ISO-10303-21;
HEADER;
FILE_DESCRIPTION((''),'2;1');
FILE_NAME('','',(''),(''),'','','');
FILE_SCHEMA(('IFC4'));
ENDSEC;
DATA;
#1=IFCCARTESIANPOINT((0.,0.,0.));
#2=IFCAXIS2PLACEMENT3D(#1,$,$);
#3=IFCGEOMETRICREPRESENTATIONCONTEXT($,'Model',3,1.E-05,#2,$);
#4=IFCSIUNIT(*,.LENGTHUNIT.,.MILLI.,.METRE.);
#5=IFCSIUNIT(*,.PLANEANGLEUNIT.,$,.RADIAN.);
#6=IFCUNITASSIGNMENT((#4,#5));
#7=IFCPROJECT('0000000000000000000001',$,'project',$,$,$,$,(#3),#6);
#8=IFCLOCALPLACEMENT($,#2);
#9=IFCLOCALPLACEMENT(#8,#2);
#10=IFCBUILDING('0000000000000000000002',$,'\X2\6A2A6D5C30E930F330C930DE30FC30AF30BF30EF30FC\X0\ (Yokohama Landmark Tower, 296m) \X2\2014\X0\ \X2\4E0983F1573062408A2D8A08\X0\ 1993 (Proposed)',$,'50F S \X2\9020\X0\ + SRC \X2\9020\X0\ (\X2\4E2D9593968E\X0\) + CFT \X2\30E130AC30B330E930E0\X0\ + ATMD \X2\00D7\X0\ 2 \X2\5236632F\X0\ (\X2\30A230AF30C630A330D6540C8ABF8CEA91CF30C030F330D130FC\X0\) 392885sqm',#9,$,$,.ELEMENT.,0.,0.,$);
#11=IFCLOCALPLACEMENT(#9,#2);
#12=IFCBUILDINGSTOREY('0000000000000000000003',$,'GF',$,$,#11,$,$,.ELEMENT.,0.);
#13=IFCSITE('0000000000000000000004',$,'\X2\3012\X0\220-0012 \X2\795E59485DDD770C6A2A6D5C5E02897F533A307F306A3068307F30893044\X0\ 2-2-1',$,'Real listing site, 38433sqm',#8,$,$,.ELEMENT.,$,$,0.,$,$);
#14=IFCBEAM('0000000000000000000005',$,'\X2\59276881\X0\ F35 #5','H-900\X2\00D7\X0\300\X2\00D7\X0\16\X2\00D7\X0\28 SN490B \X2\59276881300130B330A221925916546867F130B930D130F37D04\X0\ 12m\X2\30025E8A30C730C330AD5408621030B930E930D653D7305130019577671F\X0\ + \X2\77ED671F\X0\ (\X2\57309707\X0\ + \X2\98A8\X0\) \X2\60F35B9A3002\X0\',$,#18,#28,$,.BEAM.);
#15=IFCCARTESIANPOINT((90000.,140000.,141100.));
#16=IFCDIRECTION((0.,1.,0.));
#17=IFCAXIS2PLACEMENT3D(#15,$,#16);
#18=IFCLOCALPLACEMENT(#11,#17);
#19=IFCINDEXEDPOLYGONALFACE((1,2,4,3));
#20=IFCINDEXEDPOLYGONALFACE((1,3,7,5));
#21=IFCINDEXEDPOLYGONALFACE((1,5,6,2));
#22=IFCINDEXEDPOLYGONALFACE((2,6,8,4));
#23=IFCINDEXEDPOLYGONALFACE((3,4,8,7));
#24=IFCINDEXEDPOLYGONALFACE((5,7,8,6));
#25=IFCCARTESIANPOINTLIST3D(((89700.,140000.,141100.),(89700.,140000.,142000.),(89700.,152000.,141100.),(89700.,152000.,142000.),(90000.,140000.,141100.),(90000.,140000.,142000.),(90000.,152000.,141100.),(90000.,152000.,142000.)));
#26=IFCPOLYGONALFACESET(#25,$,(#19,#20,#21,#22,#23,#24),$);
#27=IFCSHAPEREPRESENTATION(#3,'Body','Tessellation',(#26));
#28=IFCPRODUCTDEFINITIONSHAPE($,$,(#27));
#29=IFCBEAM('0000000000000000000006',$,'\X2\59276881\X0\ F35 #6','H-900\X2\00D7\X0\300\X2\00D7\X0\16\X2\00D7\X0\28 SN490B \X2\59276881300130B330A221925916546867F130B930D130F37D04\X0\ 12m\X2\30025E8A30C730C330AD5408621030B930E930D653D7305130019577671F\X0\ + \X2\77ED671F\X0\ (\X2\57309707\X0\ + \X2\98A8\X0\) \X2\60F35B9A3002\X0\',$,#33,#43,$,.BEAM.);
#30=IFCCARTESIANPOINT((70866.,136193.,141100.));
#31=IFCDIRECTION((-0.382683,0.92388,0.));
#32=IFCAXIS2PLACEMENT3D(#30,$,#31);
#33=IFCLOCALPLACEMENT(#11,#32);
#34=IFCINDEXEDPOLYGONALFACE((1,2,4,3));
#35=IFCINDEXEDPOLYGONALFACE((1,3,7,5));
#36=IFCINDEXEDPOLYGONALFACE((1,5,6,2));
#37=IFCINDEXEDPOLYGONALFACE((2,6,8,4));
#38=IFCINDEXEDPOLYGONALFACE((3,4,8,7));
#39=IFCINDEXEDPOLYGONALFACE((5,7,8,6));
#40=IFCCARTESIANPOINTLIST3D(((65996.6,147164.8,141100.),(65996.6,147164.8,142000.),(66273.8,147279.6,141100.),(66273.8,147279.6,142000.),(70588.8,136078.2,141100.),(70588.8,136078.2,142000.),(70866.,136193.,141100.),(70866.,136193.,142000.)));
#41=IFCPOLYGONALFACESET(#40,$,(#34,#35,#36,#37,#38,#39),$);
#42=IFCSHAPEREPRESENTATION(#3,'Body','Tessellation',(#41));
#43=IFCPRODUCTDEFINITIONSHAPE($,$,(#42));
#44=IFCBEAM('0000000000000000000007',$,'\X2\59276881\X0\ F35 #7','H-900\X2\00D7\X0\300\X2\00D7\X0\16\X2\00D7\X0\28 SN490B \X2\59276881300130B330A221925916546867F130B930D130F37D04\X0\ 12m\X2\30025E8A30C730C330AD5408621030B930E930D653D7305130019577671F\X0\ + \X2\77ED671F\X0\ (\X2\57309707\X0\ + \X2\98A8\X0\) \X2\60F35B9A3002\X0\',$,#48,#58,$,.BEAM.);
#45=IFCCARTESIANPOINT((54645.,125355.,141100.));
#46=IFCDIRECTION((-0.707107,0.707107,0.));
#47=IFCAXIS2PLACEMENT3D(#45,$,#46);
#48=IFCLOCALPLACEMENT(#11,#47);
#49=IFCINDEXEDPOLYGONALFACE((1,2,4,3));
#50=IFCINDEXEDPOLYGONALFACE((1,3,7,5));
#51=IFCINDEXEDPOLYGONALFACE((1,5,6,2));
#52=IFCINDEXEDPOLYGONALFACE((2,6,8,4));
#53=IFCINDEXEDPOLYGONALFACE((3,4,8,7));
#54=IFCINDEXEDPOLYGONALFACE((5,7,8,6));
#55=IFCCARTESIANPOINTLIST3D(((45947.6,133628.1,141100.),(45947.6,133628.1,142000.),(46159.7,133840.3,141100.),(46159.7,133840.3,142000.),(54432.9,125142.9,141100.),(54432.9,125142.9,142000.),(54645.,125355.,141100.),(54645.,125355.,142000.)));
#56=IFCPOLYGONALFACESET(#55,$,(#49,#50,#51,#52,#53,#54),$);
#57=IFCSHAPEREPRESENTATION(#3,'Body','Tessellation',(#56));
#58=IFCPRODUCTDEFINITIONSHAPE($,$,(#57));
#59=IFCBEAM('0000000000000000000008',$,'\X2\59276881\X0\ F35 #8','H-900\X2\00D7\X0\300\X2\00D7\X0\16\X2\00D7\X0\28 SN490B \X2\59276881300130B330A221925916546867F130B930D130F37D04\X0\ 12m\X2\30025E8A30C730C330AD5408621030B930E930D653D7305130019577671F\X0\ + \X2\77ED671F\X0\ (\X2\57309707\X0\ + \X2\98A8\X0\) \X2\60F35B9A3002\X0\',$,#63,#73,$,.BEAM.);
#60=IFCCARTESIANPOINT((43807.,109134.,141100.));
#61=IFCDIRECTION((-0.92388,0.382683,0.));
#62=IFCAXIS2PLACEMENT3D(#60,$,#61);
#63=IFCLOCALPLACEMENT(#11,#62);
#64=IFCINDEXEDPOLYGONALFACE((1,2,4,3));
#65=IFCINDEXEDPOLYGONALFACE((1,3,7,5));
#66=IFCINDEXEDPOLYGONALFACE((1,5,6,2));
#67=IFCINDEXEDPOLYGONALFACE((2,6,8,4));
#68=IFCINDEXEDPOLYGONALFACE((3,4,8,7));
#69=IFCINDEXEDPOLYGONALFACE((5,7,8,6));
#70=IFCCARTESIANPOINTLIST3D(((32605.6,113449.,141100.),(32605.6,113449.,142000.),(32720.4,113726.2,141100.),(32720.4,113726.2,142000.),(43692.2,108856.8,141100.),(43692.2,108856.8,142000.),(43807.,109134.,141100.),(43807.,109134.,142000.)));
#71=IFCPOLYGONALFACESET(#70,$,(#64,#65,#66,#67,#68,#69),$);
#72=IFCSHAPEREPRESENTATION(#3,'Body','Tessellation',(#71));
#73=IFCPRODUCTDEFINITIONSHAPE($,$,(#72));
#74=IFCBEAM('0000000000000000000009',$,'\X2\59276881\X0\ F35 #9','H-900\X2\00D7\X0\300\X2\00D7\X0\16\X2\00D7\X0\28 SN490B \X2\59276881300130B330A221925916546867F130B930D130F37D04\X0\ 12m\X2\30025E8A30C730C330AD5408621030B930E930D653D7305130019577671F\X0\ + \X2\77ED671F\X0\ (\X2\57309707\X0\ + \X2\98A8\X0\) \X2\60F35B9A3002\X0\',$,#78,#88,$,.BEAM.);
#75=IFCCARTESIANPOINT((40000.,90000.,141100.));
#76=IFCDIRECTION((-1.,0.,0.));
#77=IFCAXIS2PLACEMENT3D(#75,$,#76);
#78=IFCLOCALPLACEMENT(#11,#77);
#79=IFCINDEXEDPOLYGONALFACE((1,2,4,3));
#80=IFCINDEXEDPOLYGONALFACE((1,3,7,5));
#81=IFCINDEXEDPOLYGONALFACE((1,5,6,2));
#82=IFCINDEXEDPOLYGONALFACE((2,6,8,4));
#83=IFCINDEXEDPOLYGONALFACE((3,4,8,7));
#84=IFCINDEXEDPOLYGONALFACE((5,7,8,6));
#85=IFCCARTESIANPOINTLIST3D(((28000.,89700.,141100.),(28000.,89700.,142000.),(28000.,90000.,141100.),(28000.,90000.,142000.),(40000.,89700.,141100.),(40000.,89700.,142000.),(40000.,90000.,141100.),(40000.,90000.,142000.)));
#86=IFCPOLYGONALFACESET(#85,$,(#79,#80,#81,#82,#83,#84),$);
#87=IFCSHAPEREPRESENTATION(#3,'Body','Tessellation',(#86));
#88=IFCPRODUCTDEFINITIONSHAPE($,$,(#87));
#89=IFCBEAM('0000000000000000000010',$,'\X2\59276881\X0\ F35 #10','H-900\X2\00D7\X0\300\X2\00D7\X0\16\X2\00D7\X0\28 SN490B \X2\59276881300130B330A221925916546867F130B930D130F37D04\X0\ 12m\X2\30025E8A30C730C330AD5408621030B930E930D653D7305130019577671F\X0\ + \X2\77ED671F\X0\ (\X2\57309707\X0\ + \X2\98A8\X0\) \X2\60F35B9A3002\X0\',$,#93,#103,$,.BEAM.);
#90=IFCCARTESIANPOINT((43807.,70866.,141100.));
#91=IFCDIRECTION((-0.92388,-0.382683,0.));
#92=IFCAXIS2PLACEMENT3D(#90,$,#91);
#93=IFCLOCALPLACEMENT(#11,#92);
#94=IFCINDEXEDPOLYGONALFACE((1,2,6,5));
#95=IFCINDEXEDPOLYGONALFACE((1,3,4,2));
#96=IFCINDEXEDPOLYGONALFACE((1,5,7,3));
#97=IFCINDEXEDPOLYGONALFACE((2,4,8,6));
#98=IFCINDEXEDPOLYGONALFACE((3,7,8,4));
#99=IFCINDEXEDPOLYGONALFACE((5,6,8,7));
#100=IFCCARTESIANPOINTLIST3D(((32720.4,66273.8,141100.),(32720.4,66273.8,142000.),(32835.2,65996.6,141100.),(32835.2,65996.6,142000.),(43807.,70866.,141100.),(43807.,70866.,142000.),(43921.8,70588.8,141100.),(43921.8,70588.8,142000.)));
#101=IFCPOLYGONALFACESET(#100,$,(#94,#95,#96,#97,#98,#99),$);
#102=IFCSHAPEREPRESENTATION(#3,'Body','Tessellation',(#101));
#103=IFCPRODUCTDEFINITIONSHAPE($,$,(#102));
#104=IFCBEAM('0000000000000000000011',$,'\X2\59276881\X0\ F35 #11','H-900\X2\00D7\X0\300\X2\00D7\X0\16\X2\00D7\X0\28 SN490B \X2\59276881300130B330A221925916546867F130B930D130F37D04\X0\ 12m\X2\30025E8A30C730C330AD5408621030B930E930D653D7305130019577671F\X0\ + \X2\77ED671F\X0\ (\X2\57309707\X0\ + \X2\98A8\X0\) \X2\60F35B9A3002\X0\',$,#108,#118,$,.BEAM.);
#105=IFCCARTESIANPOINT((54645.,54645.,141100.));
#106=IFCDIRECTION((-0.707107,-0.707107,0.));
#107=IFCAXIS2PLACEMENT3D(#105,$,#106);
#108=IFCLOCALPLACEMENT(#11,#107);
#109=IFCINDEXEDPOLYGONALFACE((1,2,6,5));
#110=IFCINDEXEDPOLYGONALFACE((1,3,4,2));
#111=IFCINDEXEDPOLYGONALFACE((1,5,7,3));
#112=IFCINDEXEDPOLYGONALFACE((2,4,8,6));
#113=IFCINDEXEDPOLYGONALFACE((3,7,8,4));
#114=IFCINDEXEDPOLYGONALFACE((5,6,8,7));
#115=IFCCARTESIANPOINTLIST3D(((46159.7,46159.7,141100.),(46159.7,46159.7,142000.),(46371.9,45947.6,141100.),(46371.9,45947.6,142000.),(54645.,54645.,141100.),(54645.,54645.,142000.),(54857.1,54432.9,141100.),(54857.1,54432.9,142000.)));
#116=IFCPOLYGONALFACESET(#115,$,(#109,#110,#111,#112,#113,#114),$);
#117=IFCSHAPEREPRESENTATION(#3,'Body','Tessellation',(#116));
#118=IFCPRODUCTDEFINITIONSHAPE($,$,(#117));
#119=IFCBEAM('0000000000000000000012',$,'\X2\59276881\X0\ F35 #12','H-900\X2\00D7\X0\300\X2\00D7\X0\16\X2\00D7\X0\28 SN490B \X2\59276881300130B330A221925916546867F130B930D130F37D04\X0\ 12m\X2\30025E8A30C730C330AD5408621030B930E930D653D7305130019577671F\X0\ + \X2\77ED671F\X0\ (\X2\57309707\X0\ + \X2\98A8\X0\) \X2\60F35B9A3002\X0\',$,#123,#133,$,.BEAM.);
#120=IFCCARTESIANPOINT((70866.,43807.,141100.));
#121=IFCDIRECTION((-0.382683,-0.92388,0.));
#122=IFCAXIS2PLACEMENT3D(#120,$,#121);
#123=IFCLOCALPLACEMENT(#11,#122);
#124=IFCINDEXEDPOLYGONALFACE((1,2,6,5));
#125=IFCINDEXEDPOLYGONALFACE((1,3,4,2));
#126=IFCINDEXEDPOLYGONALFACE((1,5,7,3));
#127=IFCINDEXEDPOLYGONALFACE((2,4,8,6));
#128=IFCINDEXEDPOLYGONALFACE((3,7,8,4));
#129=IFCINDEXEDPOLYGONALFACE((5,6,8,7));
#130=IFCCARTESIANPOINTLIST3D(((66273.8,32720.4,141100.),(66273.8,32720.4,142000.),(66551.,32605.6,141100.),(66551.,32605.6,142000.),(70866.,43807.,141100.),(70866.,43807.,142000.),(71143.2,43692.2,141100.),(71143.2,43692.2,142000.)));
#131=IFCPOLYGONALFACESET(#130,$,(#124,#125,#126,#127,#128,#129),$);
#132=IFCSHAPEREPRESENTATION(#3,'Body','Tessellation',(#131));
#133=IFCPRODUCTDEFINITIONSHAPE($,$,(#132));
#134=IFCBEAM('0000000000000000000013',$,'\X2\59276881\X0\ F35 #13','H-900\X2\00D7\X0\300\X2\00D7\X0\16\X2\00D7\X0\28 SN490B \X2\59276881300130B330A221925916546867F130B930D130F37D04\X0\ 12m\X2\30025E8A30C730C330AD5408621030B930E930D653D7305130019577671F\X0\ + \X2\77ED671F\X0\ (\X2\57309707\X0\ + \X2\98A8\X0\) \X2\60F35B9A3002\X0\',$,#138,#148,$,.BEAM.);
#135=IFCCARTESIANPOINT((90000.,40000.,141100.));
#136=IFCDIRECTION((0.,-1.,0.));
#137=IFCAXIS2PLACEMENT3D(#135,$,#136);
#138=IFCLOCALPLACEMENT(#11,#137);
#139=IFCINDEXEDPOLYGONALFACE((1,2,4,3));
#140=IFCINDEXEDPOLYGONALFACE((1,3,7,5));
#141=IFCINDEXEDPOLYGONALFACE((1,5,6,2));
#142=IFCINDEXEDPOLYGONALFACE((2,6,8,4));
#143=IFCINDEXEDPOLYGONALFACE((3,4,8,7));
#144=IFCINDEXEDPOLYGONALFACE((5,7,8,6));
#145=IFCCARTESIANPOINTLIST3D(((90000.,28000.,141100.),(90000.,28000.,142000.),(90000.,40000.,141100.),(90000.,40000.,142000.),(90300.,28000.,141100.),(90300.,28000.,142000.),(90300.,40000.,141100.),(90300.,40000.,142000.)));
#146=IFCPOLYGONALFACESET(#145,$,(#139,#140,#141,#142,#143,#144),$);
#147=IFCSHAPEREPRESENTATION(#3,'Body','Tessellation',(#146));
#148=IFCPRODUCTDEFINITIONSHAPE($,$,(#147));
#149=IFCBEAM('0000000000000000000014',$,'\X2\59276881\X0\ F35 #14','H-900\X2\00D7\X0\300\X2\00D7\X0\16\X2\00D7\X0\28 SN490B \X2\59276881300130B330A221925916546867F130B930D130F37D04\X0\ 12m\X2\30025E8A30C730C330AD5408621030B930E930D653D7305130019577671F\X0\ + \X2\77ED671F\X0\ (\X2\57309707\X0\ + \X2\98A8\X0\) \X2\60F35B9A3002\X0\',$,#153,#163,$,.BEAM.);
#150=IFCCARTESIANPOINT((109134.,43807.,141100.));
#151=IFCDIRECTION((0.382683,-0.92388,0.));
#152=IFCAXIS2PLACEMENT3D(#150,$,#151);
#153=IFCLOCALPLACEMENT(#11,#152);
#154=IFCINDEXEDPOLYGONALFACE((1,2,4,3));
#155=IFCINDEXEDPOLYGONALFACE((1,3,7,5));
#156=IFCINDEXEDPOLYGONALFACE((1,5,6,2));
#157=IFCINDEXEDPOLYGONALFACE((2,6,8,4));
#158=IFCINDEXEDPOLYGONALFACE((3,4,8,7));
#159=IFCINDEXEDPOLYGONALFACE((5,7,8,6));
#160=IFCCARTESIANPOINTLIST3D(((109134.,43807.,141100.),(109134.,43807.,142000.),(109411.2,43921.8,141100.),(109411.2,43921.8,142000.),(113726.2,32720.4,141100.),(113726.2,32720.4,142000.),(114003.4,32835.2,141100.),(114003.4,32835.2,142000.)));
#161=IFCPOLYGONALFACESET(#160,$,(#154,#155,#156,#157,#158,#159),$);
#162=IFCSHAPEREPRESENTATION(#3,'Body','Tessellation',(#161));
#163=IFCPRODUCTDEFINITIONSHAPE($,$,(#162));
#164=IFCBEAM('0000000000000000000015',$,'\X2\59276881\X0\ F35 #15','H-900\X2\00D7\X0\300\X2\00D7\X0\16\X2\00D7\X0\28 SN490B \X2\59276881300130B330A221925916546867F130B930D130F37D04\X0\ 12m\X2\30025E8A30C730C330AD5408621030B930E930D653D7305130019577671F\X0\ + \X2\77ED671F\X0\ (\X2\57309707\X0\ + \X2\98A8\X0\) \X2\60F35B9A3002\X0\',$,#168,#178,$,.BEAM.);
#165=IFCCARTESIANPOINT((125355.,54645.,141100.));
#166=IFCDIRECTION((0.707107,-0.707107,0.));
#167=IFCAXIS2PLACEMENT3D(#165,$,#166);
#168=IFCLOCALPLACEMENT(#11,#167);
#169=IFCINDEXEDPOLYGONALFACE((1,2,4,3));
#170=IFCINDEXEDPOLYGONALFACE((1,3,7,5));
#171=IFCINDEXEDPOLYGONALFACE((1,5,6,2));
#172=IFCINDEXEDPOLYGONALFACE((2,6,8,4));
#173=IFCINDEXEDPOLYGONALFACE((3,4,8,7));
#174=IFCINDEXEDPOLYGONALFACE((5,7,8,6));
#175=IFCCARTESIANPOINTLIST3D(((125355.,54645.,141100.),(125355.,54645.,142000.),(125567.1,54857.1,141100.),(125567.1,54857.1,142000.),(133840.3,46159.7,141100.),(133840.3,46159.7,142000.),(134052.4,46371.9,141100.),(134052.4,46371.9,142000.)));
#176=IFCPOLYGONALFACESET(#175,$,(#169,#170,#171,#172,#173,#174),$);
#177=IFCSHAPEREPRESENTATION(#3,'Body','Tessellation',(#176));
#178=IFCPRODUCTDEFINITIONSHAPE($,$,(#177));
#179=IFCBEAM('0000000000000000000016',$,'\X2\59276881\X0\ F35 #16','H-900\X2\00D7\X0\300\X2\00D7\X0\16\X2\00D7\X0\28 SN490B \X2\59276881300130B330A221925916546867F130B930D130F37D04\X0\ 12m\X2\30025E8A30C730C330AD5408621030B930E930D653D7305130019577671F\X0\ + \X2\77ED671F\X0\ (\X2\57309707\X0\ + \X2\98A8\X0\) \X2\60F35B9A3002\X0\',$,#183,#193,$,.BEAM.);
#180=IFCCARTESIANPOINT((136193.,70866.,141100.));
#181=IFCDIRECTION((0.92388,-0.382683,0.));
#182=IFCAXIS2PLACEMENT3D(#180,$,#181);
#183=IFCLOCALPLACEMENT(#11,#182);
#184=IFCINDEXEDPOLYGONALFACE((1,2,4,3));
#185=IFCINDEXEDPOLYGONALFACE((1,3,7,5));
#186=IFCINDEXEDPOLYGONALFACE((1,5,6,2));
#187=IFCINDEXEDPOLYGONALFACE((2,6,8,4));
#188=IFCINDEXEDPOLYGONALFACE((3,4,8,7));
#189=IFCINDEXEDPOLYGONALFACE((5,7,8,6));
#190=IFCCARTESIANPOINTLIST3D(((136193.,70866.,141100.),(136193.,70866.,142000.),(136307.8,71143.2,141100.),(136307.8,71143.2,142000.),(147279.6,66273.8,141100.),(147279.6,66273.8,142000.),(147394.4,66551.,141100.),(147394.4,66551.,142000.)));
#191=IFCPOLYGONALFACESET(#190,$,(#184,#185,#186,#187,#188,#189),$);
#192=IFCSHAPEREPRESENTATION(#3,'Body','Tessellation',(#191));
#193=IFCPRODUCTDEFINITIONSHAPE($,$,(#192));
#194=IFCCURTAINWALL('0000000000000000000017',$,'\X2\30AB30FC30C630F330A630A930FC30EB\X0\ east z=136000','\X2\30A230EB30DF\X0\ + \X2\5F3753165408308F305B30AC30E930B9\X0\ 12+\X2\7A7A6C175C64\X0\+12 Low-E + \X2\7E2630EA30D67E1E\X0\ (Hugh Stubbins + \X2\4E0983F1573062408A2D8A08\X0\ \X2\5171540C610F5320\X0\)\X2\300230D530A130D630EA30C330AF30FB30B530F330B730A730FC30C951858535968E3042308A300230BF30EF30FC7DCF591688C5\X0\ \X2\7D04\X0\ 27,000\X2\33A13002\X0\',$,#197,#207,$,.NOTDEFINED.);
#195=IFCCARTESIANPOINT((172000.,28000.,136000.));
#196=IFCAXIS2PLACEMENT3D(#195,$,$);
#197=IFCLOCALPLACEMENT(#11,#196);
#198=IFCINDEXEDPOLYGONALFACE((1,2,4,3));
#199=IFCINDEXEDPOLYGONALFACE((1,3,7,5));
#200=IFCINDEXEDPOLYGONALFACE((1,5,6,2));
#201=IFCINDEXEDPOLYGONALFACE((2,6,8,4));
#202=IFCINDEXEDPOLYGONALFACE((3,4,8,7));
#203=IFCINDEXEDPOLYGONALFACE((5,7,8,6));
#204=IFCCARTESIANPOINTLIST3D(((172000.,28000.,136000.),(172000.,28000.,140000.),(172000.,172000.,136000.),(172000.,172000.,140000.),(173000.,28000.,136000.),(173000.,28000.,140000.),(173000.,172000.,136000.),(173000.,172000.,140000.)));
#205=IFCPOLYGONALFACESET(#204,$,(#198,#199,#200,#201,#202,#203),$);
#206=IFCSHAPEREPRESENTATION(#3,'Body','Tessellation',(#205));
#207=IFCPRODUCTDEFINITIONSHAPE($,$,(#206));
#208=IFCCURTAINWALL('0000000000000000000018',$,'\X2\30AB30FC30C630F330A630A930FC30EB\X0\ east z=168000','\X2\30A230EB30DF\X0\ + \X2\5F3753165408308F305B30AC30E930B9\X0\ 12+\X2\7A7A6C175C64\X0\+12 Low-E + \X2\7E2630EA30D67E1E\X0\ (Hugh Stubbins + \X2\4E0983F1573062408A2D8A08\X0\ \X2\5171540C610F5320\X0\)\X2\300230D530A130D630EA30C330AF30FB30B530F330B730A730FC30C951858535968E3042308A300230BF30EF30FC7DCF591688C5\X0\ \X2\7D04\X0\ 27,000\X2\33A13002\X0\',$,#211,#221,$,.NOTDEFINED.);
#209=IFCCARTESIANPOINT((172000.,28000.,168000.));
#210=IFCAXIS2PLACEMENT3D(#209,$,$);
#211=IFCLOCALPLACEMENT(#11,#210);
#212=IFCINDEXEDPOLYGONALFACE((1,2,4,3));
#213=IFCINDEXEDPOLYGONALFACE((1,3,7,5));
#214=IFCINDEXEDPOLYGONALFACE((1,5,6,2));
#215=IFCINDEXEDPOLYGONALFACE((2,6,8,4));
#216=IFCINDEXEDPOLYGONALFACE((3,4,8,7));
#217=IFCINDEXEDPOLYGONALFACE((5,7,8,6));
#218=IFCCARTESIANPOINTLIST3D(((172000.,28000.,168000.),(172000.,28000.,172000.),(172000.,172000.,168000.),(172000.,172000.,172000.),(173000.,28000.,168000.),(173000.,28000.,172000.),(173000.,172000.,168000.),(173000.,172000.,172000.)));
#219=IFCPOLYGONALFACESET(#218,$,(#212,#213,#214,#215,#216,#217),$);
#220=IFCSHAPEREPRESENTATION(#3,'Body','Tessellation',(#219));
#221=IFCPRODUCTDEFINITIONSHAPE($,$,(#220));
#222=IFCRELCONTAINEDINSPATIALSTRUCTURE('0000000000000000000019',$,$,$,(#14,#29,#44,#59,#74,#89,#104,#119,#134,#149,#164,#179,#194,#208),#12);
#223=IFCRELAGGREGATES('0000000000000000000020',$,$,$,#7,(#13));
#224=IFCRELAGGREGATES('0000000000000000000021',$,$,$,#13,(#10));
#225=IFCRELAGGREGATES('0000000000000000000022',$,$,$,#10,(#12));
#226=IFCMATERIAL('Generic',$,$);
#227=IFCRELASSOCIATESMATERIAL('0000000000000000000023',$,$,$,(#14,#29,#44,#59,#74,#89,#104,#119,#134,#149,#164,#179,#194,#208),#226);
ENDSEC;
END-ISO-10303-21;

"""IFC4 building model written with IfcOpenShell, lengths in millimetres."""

from ifc_helpers import new_model, si_unit, frame, frame_2d, origin, place, context, project, spatial, rectangle, extrude, material, element, save


model = new_model("IFC4")

# Units and contexts
model_context = context("Model", 3, precision=1e-05, world=origin())
ifc_project = project(units=[si_unit("LENGTHUNIT", "METRE", prefix="MILLI"), si_unit("PLANEANGLEUNIT", "RADIAN")], contexts=[model_context])

# Site, building, storey
site_placement = place(None, origin())
site = spatial("IfcSite", under=ifc_project, at=site_placement, Name="〒220-0012 神奈川県横浜市西区みなとみらい 2-2-1", ObjectType="Real listing site, 38433sqm", CompositionType="ELEMENT", RefElevation=0.0)
building_placement = place(site_placement, origin())
building = spatial("IfcBuilding", under=site, at=building_placement, Name="横浜ランドマークタワー (Yokohama Landmark Tower, 296m) — 三菱地所設計 1993 (Proposed)", ObjectType="50F S 造 + SRC 造 (中間階) + CFT メガコラム + ATMD × 2 制振 (アクティブ同調質量ダンパー) 392885sqm", CompositionType="ELEMENT", ElevationOfRefHeight=0.0, ElevationOfTerrain=0.0)
storey_placement = place(building_placement, origin())
storey = spatial("IfcBuildingStorey", under=building, at=storey_placement, Name="GF", CompositionType="ELEMENT", Elevation=0.0)

# Beams
ifc_material_1 = material(Name="Generic")
beam_1_placement = place(storey_placement, frame((90000.0, 140000.0, 141100.0), x_axis=(0.0, 1.0, 0.0)))
element("IfcBeam", 1, at=beam_1_placement, inside=storey, material=ifc_material_1, Name="大梁 F35 #5", Description="H-900×300×16×28 SN490B 大梁、コア→外周柱スパン約 12m。床デッキ合成スラブ受け、長期 + 短期 (地震 + 風) 想定。", PredefinedType="BEAM", context=model_context, shape_type="SweptSolid", body=[
    extrude(rectangle(XDim=12000.0, YDim=300.0, at=frame_2d((6000.0, 150.0))), frame((90000.0, 140000.0, 141100.0), x_axis=(0.0, 1.0, 0.0)), (0.0, 0.0, 1.0), 900.0),
])
beam_2_placement = place(storey_placement, frame((70866.0, 136193.0, 141100.0), x_axis=(-0.382683, 0.92388, 0.0)))
element("IfcBeam", 2, at=beam_2_placement, inside=storey, material=ifc_material_1, Name="大梁 F35 #6", Description="H-900×300×16×28 SN490B 大梁、コア→外周柱スパン約 12m。床デッキ合成スラブ受け、長期 + 短期 (地震 + 風) 想定。", PredefinedType="BEAM", context=model_context, shape_type="SweptSolid", body=[
    extrude(rectangle(XDim=12000.0, YDim=300.0, at=frame_2d((6000.0, 150.0))), frame((70866.0, 136193.0, 141100.0), x_axis=(-0.382683, 0.92388, 0.0)), (0.0, 0.0, 1.0), 900.0),
])
beam_3_placement = place(storey_placement, frame((54645.0, 125355.0, 141100.0), x_axis=(-0.707107, 0.707107, 0.0)))
element("IfcBeam", 3, at=beam_3_placement, inside=storey, material=ifc_material_1, Name="大梁 F35 #7", Description="H-900×300×16×28 SN490B 大梁、コア→外周柱スパン約 12m。床デッキ合成スラブ受け、長期 + 短期 (地震 + 風) 想定。", PredefinedType="BEAM", context=model_context, shape_type="SweptSolid", body=[
    extrude(rectangle(XDim=12000.0, YDim=300.0, at=frame_2d((6000.0, 150.0))), frame((54645.0, 125355.0, 141100.0), x_axis=(-0.707107, 0.707107, 0.0)), (0.0, 0.0, 1.0), 900.0),
])
beam_4_placement = place(storey_placement, frame((43807.0, 109134.0, 141100.0), x_axis=(-0.92388, 0.382683, 0.0)))
element("IfcBeam", 4, at=beam_4_placement, inside=storey, material=ifc_material_1, Name="大梁 F35 #8", Description="H-900×300×16×28 SN490B 大梁、コア→外周柱スパン約 12m。床デッキ合成スラブ受け、長期 + 短期 (地震 + 風) 想定。", PredefinedType="BEAM", context=model_context, shape_type="SweptSolid", body=[
    extrude(rectangle(XDim=12000.0, YDim=300.0, at=frame_2d((6000.0, 150.0))), frame((43807.0, 109134.0, 141100.0), x_axis=(-0.92388, 0.382683, 0.0)), (0.0, 0.0, 1.0), 900.0),
])
beam_5_placement = place(storey_placement, frame((40000.0, 90000.0, 141100.0), x_axis=(-1.0, 0.0, 0.0)))
element("IfcBeam", 5, at=beam_5_placement, inside=storey, material=ifc_material_1, Name="大梁 F35 #9", Description="H-900×300×16×28 SN490B 大梁、コア→外周柱スパン約 12m。床デッキ合成スラブ受け、長期 + 短期 (地震 + 風) 想定。", PredefinedType="BEAM", context=model_context, shape_type="SweptSolid", body=[
    extrude(rectangle(XDim=12000.0, YDim=300.0, at=frame_2d((6000.0, 150.0))), frame((40000.0, 90000.0, 141100.0), x_axis=(-1.0, 0.0, 0.0)), (0.0, 0.0, 1.0), 900.0),
])
beam_6_placement = place(storey_placement, frame((43807.0, 70866.0, 141100.0), x_axis=(-0.92388, -0.382683, 0.0)))
element("IfcBeam", 6, at=beam_6_placement, inside=storey, material=ifc_material_1, Name="大梁 F35 #10", Description="H-900×300×16×28 SN490B 大梁、コア→外周柱スパン約 12m。床デッキ合成スラブ受け、長期 + 短期 (地震 + 風) 想定。", PredefinedType="BEAM", context=model_context, shape_type="SweptSolid", body=[
    extrude(rectangle(XDim=12000.0, YDim=300.0, at=frame_2d((6000.0, 150.0))), frame((43807.0, 70866.0, 141100.0), x_axis=(-0.92388, -0.382683, 0.0)), (0.0, 0.0, 1.0), 900.0),
])
beam_7_placement = place(storey_placement, frame((54645.0, 54645.0, 141100.0), x_axis=(-0.707107, -0.707107, 0.0)))
element("IfcBeam", 7, at=beam_7_placement, inside=storey, material=ifc_material_1, Name="大梁 F35 #11", Description="H-900×300×16×28 SN490B 大梁、コア→外周柱スパン約 12m。床デッキ合成スラブ受け、長期 + 短期 (地震 + 風) 想定。", PredefinedType="BEAM", context=model_context, shape_type="SweptSolid", body=[
    extrude(rectangle(XDim=12000.0, YDim=300.0, at=frame_2d((6000.0, 150.0))), frame((54645.0, 54645.0, 141100.0), x_axis=(-0.707107, -0.707107, 0.0)), (0.0, 0.0, 1.0), 900.0),
])
beam_8_placement = place(storey_placement, frame((70866.0, 43807.0, 141100.0), x_axis=(-0.382683, -0.92388, 0.0)))
element("IfcBeam", 8, at=beam_8_placement, inside=storey, material=ifc_material_1, Name="大梁 F35 #12", Description="H-900×300×16×28 SN490B 大梁、コア→外周柱スパン約 12m。床デッキ合成スラブ受け、長期 + 短期 (地震 + 風) 想定。", PredefinedType="BEAM", context=model_context, shape_type="SweptSolid", body=[
    extrude(rectangle(XDim=12000.0, YDim=300.0, at=frame_2d((6000.0, 150.0))), frame((70866.0, 43807.0, 141100.0), x_axis=(-0.382683, -0.92388, 0.0)), (0.0, 0.0, 1.0), 900.0),
])
beam_9_placement = place(storey_placement, frame((90000.0, 40000.0, 141100.0), x_axis=(0.0, -1.0, 0.0)))
element("IfcBeam", 9, at=beam_9_placement, inside=storey, material=ifc_material_1, Name="大梁 F35 #13", Description="H-900×300×16×28 SN490B 大梁、コア→外周柱スパン約 12m。床デッキ合成スラブ受け、長期 + 短期 (地震 + 風) 想定。", PredefinedType="BEAM", context=model_context, shape_type="SweptSolid", body=[
    extrude(rectangle(XDim=12000.0, YDim=300.0, at=frame_2d((6000.0, 150.0))), frame((90000.0, 40000.0, 141100.0), x_axis=(0.0, -1.0, 0.0)), (0.0, 0.0, 1.0), 900.0),
])
beam_10_placement = place(storey_placement, frame((109134.0, 43807.0, 141100.0), x_axis=(0.382683, -0.92388, 0.0)))
element("IfcBeam", 10, at=beam_10_placement, inside=storey, material=ifc_material_1, Name="大梁 F35 #14", Description="H-900×300×16×28 SN490B 大梁、コア→外周柱スパン約 12m。床デッキ合成スラブ受け、長期 + 短期 (地震 + 風) 想定。", PredefinedType="BEAM", context=model_context, shape_type="SweptSolid", body=[
    extrude(rectangle(XDim=12000.0, YDim=300.0, at=frame_2d((6000.0, 150.0))), frame((109134.0, 43807.0, 141100.0), x_axis=(0.382683, -0.92388, 0.0)), (0.0, 0.0, 1.0), 900.0),
])
beam_11_placement = place(storey_placement, frame((125355.0, 54645.0, 141100.0), x_axis=(0.707107, -0.707107, 0.0)))
element("IfcBeam", 11, at=beam_11_placement, inside=storey, material=ifc_material_1, Name="大梁 F35 #15", Description="H-900×300×16×28 SN490B 大梁、コア→外周柱スパン約 12m。床デッキ合成スラブ受け、長期 + 短期 (地震 + 風) 想定。", PredefinedType="BEAM", context=model_context, shape_type="SweptSolid", body=[
    extrude(rectangle(XDim=12000.0, YDim=300.0, at=frame_2d((6000.0, 150.0))), frame((125355.0, 54645.0, 141100.0), x_axis=(0.707107, -0.707107, 0.0)), (0.0, 0.0, 1.0), 900.0),
])
beam_12_placement = place(storey_placement, frame((136193.0, 70866.0, 141100.0), x_axis=(0.92388, -0.382683, 0.0)))
element("IfcBeam", 12, at=beam_12_placement, inside=storey, material=ifc_material_1, Name="大梁 F35 #16", Description="H-900×300×16×28 SN490B 大梁、コア→外周柱スパン約 12m。床デッキ合成スラブ受け、長期 + 短期 (地震 + 風) 想定。", PredefinedType="BEAM", context=model_context, shape_type="SweptSolid", body=[
    extrude(rectangle(XDim=12000.0, YDim=300.0, at=frame_2d((6000.0, 150.0))), frame((136193.0, 70866.0, 141100.0), x_axis=(0.92388, -0.382683, 0.0)), (0.0, 0.0, 1.0), 900.0),
])

# Curtain walls
curtain_wall_1_placement = place(storey_placement, frame((172000.0, 28000.0, 136000.0)))
element("IfcCurtainWall", 13, at=curtain_wall_1_placement, inside=storey, material=ifc_material_1, Name="カーテンウォール east z=136000", Description="アルミ + 強化合わせガラス 12+空気層+12 Low-E + 縦リブ縞 (Hugh Stubbins + 三菱地所設計 共同意匠)。ファブリック・サンシェード内蔵階あり。タワー総外装 約 27,000㎡。", PredefinedType="NOTDEFINED", context=model_context, shape_type="SweptSolid", body=[
    extrude(rectangle(XDim=1000.0, YDim=144000.0, at=frame_2d((500.0, 72000.0))), frame((172000.0, 28000.0, 136000.0)), (0.0, 0.0, 1.0), 4000.0),
])
curtain_wall_2_placement = place(storey_placement, frame((172000.0, 28000.0, 168000.0)))
element("IfcCurtainWall", 14, at=curtain_wall_2_placement, inside=storey, material=ifc_material_1, Name="カーテンウォール east z=168000", Description="アルミ + 強化合わせガラス 12+空気層+12 Low-E + 縦リブ縞 (Hugh Stubbins + 三菱地所設計 共同意匠)。ファブリック・サンシェード内蔵階あり。タワー総外装 約 27,000㎡。", PredefinedType="NOTDEFINED", context=model_context, shape_type="SweptSolid", body=[
    extrude(rectangle(XDim=1000.0, YDim=144000.0, at=frame_2d((500.0, 72000.0))), frame((172000.0, 28000.0, 168000.0)), (0.0, 0.0, 1.0), 4000.0),
])

save(model, "model.ifc")
